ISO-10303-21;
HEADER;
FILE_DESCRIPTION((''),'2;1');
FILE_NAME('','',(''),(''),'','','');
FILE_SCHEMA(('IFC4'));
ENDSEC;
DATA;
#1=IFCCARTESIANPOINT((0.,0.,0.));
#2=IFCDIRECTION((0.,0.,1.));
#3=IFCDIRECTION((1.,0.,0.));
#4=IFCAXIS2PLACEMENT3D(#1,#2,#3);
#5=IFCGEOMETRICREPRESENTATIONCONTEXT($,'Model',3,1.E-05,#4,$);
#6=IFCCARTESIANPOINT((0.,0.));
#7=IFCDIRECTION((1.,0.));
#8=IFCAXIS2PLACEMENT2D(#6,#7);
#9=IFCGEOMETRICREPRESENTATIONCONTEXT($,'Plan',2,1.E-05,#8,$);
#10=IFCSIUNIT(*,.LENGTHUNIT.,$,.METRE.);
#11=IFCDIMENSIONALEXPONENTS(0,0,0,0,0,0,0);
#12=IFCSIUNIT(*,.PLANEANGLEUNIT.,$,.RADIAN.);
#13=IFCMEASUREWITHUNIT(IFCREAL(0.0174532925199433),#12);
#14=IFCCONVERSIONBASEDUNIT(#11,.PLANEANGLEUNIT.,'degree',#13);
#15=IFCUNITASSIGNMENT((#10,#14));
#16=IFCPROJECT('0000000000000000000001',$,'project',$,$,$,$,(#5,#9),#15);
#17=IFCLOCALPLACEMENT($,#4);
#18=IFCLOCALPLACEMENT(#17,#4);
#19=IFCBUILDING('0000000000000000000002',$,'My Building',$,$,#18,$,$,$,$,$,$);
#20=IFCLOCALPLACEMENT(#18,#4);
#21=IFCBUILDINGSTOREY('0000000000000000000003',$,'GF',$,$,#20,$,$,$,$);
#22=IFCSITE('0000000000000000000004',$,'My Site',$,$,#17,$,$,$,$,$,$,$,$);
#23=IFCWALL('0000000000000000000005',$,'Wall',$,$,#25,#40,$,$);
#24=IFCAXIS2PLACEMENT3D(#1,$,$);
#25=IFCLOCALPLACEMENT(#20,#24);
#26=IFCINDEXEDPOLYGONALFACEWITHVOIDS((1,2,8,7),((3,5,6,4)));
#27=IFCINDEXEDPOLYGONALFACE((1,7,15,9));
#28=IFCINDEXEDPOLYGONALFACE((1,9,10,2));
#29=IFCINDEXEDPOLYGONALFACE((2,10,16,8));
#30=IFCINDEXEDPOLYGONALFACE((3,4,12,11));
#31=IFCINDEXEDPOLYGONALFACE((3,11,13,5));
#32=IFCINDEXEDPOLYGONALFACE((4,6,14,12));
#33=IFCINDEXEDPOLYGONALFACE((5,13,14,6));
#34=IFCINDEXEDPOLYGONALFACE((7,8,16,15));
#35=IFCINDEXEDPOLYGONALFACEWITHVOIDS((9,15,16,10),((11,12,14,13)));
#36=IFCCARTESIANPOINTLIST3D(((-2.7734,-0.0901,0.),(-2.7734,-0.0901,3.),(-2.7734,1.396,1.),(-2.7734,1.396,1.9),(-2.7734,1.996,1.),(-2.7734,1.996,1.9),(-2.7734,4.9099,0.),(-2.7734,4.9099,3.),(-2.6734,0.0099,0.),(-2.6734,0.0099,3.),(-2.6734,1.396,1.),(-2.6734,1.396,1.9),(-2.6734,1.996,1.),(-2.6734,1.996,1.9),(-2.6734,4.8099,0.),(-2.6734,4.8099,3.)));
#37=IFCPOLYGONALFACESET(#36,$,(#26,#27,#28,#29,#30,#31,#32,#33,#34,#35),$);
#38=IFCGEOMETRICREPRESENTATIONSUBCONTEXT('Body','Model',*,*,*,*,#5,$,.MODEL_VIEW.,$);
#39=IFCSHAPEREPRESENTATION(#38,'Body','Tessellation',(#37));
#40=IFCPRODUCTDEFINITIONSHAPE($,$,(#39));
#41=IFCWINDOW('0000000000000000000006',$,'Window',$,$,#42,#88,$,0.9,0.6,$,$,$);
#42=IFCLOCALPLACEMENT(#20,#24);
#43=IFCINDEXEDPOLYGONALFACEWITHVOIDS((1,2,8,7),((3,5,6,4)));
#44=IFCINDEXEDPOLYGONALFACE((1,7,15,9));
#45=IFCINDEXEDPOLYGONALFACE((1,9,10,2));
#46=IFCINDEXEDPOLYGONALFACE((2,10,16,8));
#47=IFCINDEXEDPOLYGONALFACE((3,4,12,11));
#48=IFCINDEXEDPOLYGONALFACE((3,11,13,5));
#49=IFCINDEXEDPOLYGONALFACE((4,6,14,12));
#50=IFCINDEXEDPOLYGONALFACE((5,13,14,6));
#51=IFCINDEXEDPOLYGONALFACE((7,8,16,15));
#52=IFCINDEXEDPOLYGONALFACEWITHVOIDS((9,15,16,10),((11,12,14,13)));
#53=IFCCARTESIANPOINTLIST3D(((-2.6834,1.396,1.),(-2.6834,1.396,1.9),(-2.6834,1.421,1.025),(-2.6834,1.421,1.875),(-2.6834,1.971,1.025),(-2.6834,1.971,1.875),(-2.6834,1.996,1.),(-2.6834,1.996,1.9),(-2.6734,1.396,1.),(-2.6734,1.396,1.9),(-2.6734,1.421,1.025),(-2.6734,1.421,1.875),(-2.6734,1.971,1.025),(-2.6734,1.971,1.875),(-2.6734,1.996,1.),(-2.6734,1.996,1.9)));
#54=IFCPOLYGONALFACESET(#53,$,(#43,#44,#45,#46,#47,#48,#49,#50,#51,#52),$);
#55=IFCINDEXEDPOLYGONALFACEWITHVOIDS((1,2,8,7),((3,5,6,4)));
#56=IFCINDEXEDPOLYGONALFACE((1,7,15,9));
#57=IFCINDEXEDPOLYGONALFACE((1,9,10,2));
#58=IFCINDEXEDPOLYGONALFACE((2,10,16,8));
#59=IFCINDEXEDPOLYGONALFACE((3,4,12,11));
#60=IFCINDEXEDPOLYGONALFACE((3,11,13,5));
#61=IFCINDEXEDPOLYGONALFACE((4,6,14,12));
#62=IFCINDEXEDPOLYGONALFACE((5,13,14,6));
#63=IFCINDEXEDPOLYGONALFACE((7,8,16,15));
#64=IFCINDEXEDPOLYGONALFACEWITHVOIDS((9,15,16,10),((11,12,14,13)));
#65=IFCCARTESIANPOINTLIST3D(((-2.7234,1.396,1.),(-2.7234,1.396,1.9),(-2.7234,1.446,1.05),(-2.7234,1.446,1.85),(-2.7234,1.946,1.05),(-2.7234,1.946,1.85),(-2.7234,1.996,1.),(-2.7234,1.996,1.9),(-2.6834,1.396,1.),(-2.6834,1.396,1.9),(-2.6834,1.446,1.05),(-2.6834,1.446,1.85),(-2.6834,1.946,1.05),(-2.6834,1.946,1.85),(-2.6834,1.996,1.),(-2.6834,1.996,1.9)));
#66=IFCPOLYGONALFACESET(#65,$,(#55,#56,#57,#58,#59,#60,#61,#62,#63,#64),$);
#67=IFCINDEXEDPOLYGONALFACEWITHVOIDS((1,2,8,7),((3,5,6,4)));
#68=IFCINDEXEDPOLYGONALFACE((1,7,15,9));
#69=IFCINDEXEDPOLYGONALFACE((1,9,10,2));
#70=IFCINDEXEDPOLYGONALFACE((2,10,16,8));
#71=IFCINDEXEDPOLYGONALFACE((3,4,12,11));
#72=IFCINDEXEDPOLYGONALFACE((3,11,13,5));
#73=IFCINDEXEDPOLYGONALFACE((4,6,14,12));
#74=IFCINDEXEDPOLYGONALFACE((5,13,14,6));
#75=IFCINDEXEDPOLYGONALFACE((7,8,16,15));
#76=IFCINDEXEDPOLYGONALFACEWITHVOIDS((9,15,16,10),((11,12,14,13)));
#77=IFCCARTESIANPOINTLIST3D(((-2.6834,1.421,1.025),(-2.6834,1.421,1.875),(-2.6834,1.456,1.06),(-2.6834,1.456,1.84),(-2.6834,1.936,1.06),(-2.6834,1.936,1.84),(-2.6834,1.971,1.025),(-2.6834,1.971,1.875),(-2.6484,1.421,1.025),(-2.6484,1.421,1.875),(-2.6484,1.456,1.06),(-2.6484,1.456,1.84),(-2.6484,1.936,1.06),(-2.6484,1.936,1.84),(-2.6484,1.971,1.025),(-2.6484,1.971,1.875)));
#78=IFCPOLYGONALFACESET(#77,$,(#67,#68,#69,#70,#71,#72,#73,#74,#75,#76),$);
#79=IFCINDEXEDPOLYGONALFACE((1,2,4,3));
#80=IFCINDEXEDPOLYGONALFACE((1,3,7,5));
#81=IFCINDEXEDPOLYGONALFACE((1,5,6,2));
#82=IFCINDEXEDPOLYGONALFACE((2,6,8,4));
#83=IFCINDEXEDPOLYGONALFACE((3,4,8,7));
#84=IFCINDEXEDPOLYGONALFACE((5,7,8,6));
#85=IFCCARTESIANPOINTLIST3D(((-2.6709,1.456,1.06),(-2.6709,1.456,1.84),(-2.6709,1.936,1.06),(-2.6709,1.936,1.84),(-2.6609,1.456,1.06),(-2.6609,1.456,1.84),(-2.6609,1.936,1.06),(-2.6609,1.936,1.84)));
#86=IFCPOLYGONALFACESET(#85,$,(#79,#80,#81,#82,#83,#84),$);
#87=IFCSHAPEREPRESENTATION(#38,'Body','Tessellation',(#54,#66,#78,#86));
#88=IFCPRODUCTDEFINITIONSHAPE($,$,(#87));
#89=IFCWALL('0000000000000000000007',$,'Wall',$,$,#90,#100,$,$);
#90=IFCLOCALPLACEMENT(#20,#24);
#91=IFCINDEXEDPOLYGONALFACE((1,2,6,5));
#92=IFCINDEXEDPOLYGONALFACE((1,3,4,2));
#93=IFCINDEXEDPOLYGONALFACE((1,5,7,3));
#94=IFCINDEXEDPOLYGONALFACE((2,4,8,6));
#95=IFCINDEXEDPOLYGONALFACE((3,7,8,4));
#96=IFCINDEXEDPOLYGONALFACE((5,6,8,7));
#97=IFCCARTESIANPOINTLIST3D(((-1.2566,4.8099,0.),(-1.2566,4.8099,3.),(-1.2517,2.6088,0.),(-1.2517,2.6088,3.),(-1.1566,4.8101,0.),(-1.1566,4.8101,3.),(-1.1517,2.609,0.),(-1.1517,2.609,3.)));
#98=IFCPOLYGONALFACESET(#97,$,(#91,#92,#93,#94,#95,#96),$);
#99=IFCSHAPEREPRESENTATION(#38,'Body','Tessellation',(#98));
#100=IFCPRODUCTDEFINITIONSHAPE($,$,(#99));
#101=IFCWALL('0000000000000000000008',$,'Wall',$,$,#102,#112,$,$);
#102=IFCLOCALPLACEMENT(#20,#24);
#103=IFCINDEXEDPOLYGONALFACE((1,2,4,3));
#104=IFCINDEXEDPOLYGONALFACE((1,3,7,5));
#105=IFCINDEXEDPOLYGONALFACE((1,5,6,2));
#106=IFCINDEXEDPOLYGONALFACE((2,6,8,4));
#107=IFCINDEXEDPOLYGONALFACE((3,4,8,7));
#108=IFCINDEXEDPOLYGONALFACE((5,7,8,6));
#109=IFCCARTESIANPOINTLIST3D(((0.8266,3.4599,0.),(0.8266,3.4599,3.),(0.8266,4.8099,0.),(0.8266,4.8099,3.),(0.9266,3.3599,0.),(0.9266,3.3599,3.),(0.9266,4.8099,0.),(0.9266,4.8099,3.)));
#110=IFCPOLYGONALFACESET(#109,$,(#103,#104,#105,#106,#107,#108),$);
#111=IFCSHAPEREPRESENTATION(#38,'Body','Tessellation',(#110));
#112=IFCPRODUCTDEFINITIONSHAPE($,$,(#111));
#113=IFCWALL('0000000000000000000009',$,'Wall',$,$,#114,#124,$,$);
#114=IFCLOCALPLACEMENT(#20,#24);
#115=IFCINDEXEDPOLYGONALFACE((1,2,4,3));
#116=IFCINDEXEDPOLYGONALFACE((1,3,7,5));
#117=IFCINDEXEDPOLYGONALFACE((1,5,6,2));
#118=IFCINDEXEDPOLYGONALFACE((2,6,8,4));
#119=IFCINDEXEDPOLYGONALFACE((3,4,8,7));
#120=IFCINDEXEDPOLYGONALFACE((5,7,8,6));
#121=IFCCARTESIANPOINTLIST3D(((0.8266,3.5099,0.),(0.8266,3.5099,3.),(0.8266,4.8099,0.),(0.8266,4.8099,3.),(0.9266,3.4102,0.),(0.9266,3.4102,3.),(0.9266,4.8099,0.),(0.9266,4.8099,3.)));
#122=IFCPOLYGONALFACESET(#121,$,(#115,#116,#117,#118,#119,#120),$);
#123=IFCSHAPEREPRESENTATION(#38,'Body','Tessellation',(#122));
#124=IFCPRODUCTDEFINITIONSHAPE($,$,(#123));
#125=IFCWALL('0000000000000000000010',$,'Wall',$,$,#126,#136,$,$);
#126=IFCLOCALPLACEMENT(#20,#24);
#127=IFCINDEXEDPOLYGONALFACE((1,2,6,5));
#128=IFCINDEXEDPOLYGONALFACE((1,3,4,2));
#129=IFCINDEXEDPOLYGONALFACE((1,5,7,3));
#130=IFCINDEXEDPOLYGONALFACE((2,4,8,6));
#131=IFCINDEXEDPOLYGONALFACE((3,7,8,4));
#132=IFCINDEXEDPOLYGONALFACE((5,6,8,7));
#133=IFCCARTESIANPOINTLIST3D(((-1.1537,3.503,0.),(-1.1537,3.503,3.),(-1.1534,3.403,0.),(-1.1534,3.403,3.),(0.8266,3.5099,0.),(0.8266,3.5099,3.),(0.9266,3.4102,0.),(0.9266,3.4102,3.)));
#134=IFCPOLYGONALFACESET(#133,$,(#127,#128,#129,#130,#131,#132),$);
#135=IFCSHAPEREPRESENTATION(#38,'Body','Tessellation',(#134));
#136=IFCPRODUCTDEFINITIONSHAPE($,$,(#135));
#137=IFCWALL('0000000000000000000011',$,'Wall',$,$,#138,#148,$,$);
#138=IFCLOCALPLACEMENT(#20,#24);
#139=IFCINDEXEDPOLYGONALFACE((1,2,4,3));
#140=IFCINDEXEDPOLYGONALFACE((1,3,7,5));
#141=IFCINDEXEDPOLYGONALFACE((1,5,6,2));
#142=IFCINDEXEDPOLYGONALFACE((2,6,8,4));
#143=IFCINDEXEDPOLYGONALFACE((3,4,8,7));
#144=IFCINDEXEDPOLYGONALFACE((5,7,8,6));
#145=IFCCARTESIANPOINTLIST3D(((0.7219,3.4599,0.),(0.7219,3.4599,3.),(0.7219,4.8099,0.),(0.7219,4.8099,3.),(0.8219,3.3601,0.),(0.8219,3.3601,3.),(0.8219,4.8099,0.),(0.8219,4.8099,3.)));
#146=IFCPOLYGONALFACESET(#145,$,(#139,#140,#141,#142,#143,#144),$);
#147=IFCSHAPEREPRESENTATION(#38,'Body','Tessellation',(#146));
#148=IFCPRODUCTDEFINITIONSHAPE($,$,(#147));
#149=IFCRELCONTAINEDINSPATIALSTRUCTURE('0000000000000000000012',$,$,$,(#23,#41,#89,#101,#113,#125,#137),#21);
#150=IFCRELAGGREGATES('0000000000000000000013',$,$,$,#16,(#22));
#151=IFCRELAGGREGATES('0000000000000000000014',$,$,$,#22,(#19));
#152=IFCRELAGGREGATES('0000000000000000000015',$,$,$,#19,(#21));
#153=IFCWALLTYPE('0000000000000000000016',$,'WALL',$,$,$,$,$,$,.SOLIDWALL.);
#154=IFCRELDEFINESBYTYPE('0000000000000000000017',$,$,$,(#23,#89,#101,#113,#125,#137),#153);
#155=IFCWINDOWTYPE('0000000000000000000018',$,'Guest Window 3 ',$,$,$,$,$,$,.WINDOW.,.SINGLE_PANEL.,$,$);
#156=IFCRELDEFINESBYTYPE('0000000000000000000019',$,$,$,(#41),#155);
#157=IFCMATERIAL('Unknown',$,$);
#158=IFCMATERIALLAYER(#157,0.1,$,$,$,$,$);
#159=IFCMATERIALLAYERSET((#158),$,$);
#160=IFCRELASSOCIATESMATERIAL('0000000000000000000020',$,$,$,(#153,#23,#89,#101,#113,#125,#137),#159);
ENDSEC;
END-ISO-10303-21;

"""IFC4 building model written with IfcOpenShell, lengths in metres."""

from ifc_helpers import new_model, entity, si_unit, converted_unit, frame, origin_with_axes, origin_2d_with_axis, place, context, subcontext, project, spatial, line, indexed_curve, outline, extrude, shape, source, transform, mapped, material, layer, layer_set, layer_usage, type_object, type_shapes, element, fill, save


model = new_model("IFC4")

# Units and contexts
model_context = context("Model", 3, precision=1e-05, world=origin_with_axes())
plan_context = context("Plan", 2, precision=1e-05, world=origin_2d_with_axis())
body_context_1 = subcontext(model_context, "Body", "Model", "MODEL_VIEW")
body_context_2 = subcontext(plan_context, "Body", "Plan", "PLAN_VIEW")
ifc_project = project(units=[si_unit("LENGTHUNIT", "METRE"), converted_unit("PLANEANGLEUNIT", "degree", entity("IfcReal", 0.0174532925199433), si_unit("PLANEANGLEUNIT", "RADIAN"), dimensions=[0, 0, 0, 0, 0, 0, 0])], contexts=[model_context, plan_context])

# Site, building, storey
site_placement = place(None, origin_with_axes())
site = spatial("IfcSite", under=ifc_project, at=site_placement, Name="My Site")
building_placement = place(site_placement, origin_with_axes())
building = spatial("IfcBuilding", under=site, at=building_placement, Name="My Building")
storey_placement = place(building_placement, origin_with_axes())
storey = spatial("IfcBuildingStorey", under=building, at=storey_placement, Name="GF")

# Shared definitions
ifc_material = material(Name="Unknown")

# Shared definitions
ifc_layer_1 = layer(ifc_material, 0.1)
ifc_layer_set_1 = layer_set([ifc_layer_1])
wall_type = type_object("IfcWallType", Name="WALL", PredefinedType="SOLIDWALL", material=ifc_layer_set_1)

# Wall, opening, window
ifc_layer_usage_1 = layer_usage(ifc_layer_set_1, "AXIS2", "POSITIVE", 0.0)
wall_1_placement = place(storey_placement, frame((-2.7734, 4.9099, 0.0), z_axis=(0.0, 0.0, 1.0), x_axis=(0.0, -1.0, 0.0)))
wall_1 = element("IfcWall", 1, at=wall_1_placement, inside=storey, type_object=wall_type, material=ifc_layer_usage_1, Name="Wall", context=body_context_1, shape_type="SweptSolid", body=[
    extrude(outline(indexed_curve([(0.0, 0.0), (0.1, 0.1), (4.9, 0.1), (5.0, 0.0)], segments=[line(1, 2, 3, 4, 1)])), origin_with_axes(), (0.0, 0.0, 1.0), 3.0),
])
shared_shape_1 = source(origin_with_axes(), body_context_1, "Body", "SweptSolid", [
    extrude(outline(indexed_curve([(0.0, 0.0), (0.6, 0.0), (0.6, 0.9), (0.0, 0.9)], segments=[line(1, 2, 3, 4, 1)])), frame((0.0, -0.6, 0.0), z_axis=(0.0, -1.0, 0.0), x_axis=(1.0, 0.0, 0.0)), (0.0, 0.0, -1.0), 1.2),
])
opening_1_placement = place(wall_1_placement, frame((2.9139, 0.0, 1.0), z_axis=(0.0, 0.0, 1.0), x_axis=(1.0, 0.0, 0.0)))
opening_1 = element("IfcOpeningElement", 2, at=opening_1_placement, cuts=wall_1, PredefinedType="OPENING", context=body_context_1, shape_type="MappedRepresentation", body=[
    mapped(shared_shape_1, transform((0.0, 0.0, 0.0), x_axis=(1.0, 0.0, 0.0), y_axis=(0.0, 1.0, 0.0), z_axis=(0.0, 0.0, 1.0), scale=1.0)),
])
window_type_1 = type_object("IfcWindowType", Name="Guest Window 3 ", PartitioningType="SINGLE_PANEL", PredefinedType="WINDOW")
shared_shape_2 = source(origin_with_axes(), body_context_1, "Body", "SweptSolid", [
    extrude(outline(indexed_curve([(0.0, 0.0), (0.6, 0.0), (0.6, 0.9), (0.0, 0.9)], segments=[line(1, 2, 3, 4, 1)]), holes=[indexed_curve([(0.025, 0.025), (0.575, 0.025), (0.575, 0.875), (0.025, 0.875)], segments=[line(1, 2, 3, 4, 1)])]), frame((0.0, 0.09, 0.0), z_axis=(0.0, -1.0, 0.0), x_axis=(1.0, 0.0, 0.0)), (0.0, 0.0, -1.0), 0.01),
    extrude(outline(indexed_curve([(0.0, 0.0), (0.6, 0.0), (0.6, 0.9), (0.0, 0.9)], segments=[line(1, 2, 3, 4, 1)]), holes=[indexed_curve([(0.05, 0.05), (0.55, 0.05), (0.55, 0.85), (0.05, 0.85)], segments=[line(1, 2, 3, 4, 1)])]), frame((0.0, 0.05, 0.0), z_axis=(0.0, -1.0, 0.0), x_axis=(1.0, 0.0, 0.0)), (0.0, 0.0, -1.0), 0.04),
    extrude(outline(indexed_curve([(0.0, 0.0), (0.55, 0.0), (0.55, 0.85), (0.0, 0.85)], segments=[line(1, 2, 3, 4, 1)]), holes=[indexed_curve([(0.035, 0.035), (0.515, 0.035), (0.515, 0.815), (0.035, 0.815)], segments=[line(1, 2, 3, 4, 1)])]), frame((0.025, 0.09, 0.025), z_axis=(0.0, -1.0, 0.0), x_axis=(1.0, 0.0, 0.0)), (0.0, 0.0, -1.0), 0.035),
    extrude(outline(indexed_curve([(0.035, 0.035), (0.515, 0.035), (0.515, 0.815), (0.035, 0.815)], segments=[line(1, 2, 3, 4, 1)])), frame((0.025, 0.1025, 0.025), z_axis=(0.0, -1.0, 0.0), x_axis=(1.0, 0.0, 0.0)), (0.0, 0.0, -1.0), 0.01),
])
shared_shape_3 = source(origin_with_axes(), body_context_2, "Body", "Curve2D", [
    entity("IfcIndexedPolyCurve", entity("IfcCartesianPointList2D", [[0.05, 0.05], [0.55, 0.05]])),
    entity("IfcIndexedPolyCurve", entity("IfcCartesianPointList2D", [[0.0, 0.1], [0.025, 0.1], [0.025, 0.09], [0.05, 0.09], [0.05, 0.05], [0.0, 0.05]]), [entity("IfcLineIndex", [1, 2, 3, 4, 5, 6, 1])]),
    entity("IfcIndexedPolyCurve", entity("IfcCartesianPointList2D", [[0.6, 0.1], [0.575, 0.1], [0.575, 0.09], [0.55, 0.09], [0.55, 0.05], [0.6, 0.05]]), [entity("IfcLineIndex", [1, 2, 3, 4, 5, 6, 1])]),
    entity("IfcIndexedPolyCurve", entity("IfcCartesianPointList2D", [[0.025, 0.09], [0.06, 0.09], [0.06, 0.125], [0.025, 0.125]]), [entity("IfcLineIndex", [1, 2, 3, 4, 1])]),
    entity("IfcIndexedPolyCurve", entity("IfcCartesianPointList2D", [[0.575, 0.09], [0.54, 0.09], [0.54, 0.125], [0.575, 0.125]]), [entity("IfcLineIndex", [1, 2, 3, 4, 1])]),
    entity("IfcIndexedPolyCurve", entity("IfcCartesianPointList2D", [[0.06, 0.09], [0.54, 0.09]])),
    entity("IfcIndexedPolyCurve", entity("IfcCartesianPointList2D", [[0.06, 0.125], [0.54, 0.125]])),
    entity("IfcIndexedPolyCurve", entity("IfcCartesianPointList2D", [[0.06, 0.1075], [0.54, 0.1075]])),
])
type_shapes(window_type_1, [shared_shape_2, shared_shape_3])
window_1_placement = place(opening_1_placement, origin_with_axes())
window_1 = element("IfcWindow", 3, at=window_1_placement, inside=storey, type_object=window_type_1, Name="Window", OverallHeight=0.9, OverallWidth=0.6, shapes=[
    shape(body_context_1, "Body", "MappedRepresentation", [mapped(shared_shape_2, transform((0.0, 0.0, 0.0), x_axis=(1.0, 0.0, 0.0), y_axis=(0.0, 1.0, 0.0), z_axis=(0.0, 0.0, 1.0), scale=1.0))]),
    shape(body_context_2, "Body", "MappedRepresentation", [mapped(shared_shape_3, transform((0.0, 0.0, 0.0), x_axis=(1.0, 0.0, 0.0), y_axis=(0.0, 1.0, 0.0), z_axis=(0.0, 0.0, 1.0), scale=1.0))]),
])
fill(opening_1, window_1)

# Walls
ifc_layer_usage_2 = layer_usage(ifc_layer_set_1, "AXIS2", "POSITIVE", 0.0)
wall_2_placement = place(storey_placement, frame((-1.2566, 4.8099, 0.0), z_axis=(0.0, 0.0, 1.0), x_axis=(0.002212, -0.999998, 0.0)))
element("IfcWall", 4, at=wall_2_placement, inside=storey, type_object=wall_type, material=ifc_layer_usage_2, Name="Wall", context=body_context_1, shape_type="SweptSolid", body=[
    extrude(outline(indexed_curve([(0.0, 0.0), (0.0, 0.1), (2.2011, 0.1), (2.2011, 0.0)], segments=[line(1, 2, 3, 4, 1)])), origin_with_axes(), (0.0, 0.0, 1.0), 3.0),
])
ifc_layer_usage_3 = layer_usage(ifc_layer_set_1, "AXIS2", "POSITIVE", 0.0)
wall_3_placement = place(storey_placement, frame((0.8266, 4.8099, 0.0), z_axis=(0.0, 0.0, 1.0), x_axis=(0.0, -1.0, 0.0)))
element("IfcWall", 5, at=wall_3_placement, inside=storey, type_object=wall_type, material=ifc_layer_usage_3, Name="Wall", context=body_context_1, shape_type="SweptSolid", body=[
    extrude(outline(indexed_curve([(0.0, 0.0), (0.0, 0.1), (1.45, 0.1), (1.35, 0.0)], segments=[line(1, 2, 3, 4, 1)])), origin_with_axes(), (0.0, 0.0, 1.0), 3.0),
])
ifc_layer_usage_4 = layer_usage(ifc_layer_set_1, "AXIS2", "POSITIVE", 0.0)
wall_4_placement = place(storey_placement, frame((0.8266, 4.8099, 0.0), z_axis=(0.0, 0.0, 1.0), x_axis=(0.0, -1.0, 0.0)))
element("IfcWall", 6, at=wall_4_placement, inside=storey, type_object=wall_type, material=ifc_layer_usage_4, Name="Wall", context=body_context_1, shape_type="SweptSolid", body=[
    extrude(outline(indexed_curve([(0.0, 0.0), (0.0, 0.1), (1.3997, 0.1), (1.3, 0.0)], segments=[line(1, 2, 3, 4, 1)])), origin_with_axes(), (0.0, 0.0, 1.0), 3.0),
])
ifc_layer_usage_5 = layer_usage(ifc_layer_set_1, "AXIS2", "POSITIVE", 0.0)
wall_5_placement = place(storey_placement, frame((0.8266, 3.5099, 0.0), z_axis=(0.0, 0.0, 1.0), x_axis=(-0.999994, -0.003486, 0.0)))
element("IfcWall", 7, at=wall_5_placement, inside=storey, type_object=wall_type, material=ifc_layer_usage_5, Name="Wall", context=body_context_1, shape_type="SweptSolid", body=[
    extrude(outline(indexed_curve([(0.0, 0.0), (-0.0997, 0.1), (1.9803, 0.1), (1.9803, 0.0)], segments=[line(1, 2, 3, 4, 1)])), origin_with_axes(), (0.0, 0.0, 1.0), 3.0),
])
ifc_layer_usage_6 = layer_usage(ifc_layer_set_1, "AXIS2", "POSITIVE", 0.0)
wall_6_placement = place(storey_placement, frame((0.7219, 4.8099, 0.0), z_axis=(0.0, 0.0, 1.0), x_axis=(0.0, -1.0, 0.0)))
element("IfcWall", 8, at=wall_6_placement, inside=storey, type_object=wall_type, material=ifc_layer_usage_6, Name="Wall", context=body_context_1, shape_type="SweptSolid", body=[
    extrude(outline(indexed_curve([(0.0, 0.0), (0.0, 0.1), (1.4498, 0.1), (1.35, 0.0)], segments=[line(1, 2, 3, 4, 1)])), origin_with_axes(), (0.0, 0.0, 1.0), 3.0),
])

save(model, "model.ifc")
